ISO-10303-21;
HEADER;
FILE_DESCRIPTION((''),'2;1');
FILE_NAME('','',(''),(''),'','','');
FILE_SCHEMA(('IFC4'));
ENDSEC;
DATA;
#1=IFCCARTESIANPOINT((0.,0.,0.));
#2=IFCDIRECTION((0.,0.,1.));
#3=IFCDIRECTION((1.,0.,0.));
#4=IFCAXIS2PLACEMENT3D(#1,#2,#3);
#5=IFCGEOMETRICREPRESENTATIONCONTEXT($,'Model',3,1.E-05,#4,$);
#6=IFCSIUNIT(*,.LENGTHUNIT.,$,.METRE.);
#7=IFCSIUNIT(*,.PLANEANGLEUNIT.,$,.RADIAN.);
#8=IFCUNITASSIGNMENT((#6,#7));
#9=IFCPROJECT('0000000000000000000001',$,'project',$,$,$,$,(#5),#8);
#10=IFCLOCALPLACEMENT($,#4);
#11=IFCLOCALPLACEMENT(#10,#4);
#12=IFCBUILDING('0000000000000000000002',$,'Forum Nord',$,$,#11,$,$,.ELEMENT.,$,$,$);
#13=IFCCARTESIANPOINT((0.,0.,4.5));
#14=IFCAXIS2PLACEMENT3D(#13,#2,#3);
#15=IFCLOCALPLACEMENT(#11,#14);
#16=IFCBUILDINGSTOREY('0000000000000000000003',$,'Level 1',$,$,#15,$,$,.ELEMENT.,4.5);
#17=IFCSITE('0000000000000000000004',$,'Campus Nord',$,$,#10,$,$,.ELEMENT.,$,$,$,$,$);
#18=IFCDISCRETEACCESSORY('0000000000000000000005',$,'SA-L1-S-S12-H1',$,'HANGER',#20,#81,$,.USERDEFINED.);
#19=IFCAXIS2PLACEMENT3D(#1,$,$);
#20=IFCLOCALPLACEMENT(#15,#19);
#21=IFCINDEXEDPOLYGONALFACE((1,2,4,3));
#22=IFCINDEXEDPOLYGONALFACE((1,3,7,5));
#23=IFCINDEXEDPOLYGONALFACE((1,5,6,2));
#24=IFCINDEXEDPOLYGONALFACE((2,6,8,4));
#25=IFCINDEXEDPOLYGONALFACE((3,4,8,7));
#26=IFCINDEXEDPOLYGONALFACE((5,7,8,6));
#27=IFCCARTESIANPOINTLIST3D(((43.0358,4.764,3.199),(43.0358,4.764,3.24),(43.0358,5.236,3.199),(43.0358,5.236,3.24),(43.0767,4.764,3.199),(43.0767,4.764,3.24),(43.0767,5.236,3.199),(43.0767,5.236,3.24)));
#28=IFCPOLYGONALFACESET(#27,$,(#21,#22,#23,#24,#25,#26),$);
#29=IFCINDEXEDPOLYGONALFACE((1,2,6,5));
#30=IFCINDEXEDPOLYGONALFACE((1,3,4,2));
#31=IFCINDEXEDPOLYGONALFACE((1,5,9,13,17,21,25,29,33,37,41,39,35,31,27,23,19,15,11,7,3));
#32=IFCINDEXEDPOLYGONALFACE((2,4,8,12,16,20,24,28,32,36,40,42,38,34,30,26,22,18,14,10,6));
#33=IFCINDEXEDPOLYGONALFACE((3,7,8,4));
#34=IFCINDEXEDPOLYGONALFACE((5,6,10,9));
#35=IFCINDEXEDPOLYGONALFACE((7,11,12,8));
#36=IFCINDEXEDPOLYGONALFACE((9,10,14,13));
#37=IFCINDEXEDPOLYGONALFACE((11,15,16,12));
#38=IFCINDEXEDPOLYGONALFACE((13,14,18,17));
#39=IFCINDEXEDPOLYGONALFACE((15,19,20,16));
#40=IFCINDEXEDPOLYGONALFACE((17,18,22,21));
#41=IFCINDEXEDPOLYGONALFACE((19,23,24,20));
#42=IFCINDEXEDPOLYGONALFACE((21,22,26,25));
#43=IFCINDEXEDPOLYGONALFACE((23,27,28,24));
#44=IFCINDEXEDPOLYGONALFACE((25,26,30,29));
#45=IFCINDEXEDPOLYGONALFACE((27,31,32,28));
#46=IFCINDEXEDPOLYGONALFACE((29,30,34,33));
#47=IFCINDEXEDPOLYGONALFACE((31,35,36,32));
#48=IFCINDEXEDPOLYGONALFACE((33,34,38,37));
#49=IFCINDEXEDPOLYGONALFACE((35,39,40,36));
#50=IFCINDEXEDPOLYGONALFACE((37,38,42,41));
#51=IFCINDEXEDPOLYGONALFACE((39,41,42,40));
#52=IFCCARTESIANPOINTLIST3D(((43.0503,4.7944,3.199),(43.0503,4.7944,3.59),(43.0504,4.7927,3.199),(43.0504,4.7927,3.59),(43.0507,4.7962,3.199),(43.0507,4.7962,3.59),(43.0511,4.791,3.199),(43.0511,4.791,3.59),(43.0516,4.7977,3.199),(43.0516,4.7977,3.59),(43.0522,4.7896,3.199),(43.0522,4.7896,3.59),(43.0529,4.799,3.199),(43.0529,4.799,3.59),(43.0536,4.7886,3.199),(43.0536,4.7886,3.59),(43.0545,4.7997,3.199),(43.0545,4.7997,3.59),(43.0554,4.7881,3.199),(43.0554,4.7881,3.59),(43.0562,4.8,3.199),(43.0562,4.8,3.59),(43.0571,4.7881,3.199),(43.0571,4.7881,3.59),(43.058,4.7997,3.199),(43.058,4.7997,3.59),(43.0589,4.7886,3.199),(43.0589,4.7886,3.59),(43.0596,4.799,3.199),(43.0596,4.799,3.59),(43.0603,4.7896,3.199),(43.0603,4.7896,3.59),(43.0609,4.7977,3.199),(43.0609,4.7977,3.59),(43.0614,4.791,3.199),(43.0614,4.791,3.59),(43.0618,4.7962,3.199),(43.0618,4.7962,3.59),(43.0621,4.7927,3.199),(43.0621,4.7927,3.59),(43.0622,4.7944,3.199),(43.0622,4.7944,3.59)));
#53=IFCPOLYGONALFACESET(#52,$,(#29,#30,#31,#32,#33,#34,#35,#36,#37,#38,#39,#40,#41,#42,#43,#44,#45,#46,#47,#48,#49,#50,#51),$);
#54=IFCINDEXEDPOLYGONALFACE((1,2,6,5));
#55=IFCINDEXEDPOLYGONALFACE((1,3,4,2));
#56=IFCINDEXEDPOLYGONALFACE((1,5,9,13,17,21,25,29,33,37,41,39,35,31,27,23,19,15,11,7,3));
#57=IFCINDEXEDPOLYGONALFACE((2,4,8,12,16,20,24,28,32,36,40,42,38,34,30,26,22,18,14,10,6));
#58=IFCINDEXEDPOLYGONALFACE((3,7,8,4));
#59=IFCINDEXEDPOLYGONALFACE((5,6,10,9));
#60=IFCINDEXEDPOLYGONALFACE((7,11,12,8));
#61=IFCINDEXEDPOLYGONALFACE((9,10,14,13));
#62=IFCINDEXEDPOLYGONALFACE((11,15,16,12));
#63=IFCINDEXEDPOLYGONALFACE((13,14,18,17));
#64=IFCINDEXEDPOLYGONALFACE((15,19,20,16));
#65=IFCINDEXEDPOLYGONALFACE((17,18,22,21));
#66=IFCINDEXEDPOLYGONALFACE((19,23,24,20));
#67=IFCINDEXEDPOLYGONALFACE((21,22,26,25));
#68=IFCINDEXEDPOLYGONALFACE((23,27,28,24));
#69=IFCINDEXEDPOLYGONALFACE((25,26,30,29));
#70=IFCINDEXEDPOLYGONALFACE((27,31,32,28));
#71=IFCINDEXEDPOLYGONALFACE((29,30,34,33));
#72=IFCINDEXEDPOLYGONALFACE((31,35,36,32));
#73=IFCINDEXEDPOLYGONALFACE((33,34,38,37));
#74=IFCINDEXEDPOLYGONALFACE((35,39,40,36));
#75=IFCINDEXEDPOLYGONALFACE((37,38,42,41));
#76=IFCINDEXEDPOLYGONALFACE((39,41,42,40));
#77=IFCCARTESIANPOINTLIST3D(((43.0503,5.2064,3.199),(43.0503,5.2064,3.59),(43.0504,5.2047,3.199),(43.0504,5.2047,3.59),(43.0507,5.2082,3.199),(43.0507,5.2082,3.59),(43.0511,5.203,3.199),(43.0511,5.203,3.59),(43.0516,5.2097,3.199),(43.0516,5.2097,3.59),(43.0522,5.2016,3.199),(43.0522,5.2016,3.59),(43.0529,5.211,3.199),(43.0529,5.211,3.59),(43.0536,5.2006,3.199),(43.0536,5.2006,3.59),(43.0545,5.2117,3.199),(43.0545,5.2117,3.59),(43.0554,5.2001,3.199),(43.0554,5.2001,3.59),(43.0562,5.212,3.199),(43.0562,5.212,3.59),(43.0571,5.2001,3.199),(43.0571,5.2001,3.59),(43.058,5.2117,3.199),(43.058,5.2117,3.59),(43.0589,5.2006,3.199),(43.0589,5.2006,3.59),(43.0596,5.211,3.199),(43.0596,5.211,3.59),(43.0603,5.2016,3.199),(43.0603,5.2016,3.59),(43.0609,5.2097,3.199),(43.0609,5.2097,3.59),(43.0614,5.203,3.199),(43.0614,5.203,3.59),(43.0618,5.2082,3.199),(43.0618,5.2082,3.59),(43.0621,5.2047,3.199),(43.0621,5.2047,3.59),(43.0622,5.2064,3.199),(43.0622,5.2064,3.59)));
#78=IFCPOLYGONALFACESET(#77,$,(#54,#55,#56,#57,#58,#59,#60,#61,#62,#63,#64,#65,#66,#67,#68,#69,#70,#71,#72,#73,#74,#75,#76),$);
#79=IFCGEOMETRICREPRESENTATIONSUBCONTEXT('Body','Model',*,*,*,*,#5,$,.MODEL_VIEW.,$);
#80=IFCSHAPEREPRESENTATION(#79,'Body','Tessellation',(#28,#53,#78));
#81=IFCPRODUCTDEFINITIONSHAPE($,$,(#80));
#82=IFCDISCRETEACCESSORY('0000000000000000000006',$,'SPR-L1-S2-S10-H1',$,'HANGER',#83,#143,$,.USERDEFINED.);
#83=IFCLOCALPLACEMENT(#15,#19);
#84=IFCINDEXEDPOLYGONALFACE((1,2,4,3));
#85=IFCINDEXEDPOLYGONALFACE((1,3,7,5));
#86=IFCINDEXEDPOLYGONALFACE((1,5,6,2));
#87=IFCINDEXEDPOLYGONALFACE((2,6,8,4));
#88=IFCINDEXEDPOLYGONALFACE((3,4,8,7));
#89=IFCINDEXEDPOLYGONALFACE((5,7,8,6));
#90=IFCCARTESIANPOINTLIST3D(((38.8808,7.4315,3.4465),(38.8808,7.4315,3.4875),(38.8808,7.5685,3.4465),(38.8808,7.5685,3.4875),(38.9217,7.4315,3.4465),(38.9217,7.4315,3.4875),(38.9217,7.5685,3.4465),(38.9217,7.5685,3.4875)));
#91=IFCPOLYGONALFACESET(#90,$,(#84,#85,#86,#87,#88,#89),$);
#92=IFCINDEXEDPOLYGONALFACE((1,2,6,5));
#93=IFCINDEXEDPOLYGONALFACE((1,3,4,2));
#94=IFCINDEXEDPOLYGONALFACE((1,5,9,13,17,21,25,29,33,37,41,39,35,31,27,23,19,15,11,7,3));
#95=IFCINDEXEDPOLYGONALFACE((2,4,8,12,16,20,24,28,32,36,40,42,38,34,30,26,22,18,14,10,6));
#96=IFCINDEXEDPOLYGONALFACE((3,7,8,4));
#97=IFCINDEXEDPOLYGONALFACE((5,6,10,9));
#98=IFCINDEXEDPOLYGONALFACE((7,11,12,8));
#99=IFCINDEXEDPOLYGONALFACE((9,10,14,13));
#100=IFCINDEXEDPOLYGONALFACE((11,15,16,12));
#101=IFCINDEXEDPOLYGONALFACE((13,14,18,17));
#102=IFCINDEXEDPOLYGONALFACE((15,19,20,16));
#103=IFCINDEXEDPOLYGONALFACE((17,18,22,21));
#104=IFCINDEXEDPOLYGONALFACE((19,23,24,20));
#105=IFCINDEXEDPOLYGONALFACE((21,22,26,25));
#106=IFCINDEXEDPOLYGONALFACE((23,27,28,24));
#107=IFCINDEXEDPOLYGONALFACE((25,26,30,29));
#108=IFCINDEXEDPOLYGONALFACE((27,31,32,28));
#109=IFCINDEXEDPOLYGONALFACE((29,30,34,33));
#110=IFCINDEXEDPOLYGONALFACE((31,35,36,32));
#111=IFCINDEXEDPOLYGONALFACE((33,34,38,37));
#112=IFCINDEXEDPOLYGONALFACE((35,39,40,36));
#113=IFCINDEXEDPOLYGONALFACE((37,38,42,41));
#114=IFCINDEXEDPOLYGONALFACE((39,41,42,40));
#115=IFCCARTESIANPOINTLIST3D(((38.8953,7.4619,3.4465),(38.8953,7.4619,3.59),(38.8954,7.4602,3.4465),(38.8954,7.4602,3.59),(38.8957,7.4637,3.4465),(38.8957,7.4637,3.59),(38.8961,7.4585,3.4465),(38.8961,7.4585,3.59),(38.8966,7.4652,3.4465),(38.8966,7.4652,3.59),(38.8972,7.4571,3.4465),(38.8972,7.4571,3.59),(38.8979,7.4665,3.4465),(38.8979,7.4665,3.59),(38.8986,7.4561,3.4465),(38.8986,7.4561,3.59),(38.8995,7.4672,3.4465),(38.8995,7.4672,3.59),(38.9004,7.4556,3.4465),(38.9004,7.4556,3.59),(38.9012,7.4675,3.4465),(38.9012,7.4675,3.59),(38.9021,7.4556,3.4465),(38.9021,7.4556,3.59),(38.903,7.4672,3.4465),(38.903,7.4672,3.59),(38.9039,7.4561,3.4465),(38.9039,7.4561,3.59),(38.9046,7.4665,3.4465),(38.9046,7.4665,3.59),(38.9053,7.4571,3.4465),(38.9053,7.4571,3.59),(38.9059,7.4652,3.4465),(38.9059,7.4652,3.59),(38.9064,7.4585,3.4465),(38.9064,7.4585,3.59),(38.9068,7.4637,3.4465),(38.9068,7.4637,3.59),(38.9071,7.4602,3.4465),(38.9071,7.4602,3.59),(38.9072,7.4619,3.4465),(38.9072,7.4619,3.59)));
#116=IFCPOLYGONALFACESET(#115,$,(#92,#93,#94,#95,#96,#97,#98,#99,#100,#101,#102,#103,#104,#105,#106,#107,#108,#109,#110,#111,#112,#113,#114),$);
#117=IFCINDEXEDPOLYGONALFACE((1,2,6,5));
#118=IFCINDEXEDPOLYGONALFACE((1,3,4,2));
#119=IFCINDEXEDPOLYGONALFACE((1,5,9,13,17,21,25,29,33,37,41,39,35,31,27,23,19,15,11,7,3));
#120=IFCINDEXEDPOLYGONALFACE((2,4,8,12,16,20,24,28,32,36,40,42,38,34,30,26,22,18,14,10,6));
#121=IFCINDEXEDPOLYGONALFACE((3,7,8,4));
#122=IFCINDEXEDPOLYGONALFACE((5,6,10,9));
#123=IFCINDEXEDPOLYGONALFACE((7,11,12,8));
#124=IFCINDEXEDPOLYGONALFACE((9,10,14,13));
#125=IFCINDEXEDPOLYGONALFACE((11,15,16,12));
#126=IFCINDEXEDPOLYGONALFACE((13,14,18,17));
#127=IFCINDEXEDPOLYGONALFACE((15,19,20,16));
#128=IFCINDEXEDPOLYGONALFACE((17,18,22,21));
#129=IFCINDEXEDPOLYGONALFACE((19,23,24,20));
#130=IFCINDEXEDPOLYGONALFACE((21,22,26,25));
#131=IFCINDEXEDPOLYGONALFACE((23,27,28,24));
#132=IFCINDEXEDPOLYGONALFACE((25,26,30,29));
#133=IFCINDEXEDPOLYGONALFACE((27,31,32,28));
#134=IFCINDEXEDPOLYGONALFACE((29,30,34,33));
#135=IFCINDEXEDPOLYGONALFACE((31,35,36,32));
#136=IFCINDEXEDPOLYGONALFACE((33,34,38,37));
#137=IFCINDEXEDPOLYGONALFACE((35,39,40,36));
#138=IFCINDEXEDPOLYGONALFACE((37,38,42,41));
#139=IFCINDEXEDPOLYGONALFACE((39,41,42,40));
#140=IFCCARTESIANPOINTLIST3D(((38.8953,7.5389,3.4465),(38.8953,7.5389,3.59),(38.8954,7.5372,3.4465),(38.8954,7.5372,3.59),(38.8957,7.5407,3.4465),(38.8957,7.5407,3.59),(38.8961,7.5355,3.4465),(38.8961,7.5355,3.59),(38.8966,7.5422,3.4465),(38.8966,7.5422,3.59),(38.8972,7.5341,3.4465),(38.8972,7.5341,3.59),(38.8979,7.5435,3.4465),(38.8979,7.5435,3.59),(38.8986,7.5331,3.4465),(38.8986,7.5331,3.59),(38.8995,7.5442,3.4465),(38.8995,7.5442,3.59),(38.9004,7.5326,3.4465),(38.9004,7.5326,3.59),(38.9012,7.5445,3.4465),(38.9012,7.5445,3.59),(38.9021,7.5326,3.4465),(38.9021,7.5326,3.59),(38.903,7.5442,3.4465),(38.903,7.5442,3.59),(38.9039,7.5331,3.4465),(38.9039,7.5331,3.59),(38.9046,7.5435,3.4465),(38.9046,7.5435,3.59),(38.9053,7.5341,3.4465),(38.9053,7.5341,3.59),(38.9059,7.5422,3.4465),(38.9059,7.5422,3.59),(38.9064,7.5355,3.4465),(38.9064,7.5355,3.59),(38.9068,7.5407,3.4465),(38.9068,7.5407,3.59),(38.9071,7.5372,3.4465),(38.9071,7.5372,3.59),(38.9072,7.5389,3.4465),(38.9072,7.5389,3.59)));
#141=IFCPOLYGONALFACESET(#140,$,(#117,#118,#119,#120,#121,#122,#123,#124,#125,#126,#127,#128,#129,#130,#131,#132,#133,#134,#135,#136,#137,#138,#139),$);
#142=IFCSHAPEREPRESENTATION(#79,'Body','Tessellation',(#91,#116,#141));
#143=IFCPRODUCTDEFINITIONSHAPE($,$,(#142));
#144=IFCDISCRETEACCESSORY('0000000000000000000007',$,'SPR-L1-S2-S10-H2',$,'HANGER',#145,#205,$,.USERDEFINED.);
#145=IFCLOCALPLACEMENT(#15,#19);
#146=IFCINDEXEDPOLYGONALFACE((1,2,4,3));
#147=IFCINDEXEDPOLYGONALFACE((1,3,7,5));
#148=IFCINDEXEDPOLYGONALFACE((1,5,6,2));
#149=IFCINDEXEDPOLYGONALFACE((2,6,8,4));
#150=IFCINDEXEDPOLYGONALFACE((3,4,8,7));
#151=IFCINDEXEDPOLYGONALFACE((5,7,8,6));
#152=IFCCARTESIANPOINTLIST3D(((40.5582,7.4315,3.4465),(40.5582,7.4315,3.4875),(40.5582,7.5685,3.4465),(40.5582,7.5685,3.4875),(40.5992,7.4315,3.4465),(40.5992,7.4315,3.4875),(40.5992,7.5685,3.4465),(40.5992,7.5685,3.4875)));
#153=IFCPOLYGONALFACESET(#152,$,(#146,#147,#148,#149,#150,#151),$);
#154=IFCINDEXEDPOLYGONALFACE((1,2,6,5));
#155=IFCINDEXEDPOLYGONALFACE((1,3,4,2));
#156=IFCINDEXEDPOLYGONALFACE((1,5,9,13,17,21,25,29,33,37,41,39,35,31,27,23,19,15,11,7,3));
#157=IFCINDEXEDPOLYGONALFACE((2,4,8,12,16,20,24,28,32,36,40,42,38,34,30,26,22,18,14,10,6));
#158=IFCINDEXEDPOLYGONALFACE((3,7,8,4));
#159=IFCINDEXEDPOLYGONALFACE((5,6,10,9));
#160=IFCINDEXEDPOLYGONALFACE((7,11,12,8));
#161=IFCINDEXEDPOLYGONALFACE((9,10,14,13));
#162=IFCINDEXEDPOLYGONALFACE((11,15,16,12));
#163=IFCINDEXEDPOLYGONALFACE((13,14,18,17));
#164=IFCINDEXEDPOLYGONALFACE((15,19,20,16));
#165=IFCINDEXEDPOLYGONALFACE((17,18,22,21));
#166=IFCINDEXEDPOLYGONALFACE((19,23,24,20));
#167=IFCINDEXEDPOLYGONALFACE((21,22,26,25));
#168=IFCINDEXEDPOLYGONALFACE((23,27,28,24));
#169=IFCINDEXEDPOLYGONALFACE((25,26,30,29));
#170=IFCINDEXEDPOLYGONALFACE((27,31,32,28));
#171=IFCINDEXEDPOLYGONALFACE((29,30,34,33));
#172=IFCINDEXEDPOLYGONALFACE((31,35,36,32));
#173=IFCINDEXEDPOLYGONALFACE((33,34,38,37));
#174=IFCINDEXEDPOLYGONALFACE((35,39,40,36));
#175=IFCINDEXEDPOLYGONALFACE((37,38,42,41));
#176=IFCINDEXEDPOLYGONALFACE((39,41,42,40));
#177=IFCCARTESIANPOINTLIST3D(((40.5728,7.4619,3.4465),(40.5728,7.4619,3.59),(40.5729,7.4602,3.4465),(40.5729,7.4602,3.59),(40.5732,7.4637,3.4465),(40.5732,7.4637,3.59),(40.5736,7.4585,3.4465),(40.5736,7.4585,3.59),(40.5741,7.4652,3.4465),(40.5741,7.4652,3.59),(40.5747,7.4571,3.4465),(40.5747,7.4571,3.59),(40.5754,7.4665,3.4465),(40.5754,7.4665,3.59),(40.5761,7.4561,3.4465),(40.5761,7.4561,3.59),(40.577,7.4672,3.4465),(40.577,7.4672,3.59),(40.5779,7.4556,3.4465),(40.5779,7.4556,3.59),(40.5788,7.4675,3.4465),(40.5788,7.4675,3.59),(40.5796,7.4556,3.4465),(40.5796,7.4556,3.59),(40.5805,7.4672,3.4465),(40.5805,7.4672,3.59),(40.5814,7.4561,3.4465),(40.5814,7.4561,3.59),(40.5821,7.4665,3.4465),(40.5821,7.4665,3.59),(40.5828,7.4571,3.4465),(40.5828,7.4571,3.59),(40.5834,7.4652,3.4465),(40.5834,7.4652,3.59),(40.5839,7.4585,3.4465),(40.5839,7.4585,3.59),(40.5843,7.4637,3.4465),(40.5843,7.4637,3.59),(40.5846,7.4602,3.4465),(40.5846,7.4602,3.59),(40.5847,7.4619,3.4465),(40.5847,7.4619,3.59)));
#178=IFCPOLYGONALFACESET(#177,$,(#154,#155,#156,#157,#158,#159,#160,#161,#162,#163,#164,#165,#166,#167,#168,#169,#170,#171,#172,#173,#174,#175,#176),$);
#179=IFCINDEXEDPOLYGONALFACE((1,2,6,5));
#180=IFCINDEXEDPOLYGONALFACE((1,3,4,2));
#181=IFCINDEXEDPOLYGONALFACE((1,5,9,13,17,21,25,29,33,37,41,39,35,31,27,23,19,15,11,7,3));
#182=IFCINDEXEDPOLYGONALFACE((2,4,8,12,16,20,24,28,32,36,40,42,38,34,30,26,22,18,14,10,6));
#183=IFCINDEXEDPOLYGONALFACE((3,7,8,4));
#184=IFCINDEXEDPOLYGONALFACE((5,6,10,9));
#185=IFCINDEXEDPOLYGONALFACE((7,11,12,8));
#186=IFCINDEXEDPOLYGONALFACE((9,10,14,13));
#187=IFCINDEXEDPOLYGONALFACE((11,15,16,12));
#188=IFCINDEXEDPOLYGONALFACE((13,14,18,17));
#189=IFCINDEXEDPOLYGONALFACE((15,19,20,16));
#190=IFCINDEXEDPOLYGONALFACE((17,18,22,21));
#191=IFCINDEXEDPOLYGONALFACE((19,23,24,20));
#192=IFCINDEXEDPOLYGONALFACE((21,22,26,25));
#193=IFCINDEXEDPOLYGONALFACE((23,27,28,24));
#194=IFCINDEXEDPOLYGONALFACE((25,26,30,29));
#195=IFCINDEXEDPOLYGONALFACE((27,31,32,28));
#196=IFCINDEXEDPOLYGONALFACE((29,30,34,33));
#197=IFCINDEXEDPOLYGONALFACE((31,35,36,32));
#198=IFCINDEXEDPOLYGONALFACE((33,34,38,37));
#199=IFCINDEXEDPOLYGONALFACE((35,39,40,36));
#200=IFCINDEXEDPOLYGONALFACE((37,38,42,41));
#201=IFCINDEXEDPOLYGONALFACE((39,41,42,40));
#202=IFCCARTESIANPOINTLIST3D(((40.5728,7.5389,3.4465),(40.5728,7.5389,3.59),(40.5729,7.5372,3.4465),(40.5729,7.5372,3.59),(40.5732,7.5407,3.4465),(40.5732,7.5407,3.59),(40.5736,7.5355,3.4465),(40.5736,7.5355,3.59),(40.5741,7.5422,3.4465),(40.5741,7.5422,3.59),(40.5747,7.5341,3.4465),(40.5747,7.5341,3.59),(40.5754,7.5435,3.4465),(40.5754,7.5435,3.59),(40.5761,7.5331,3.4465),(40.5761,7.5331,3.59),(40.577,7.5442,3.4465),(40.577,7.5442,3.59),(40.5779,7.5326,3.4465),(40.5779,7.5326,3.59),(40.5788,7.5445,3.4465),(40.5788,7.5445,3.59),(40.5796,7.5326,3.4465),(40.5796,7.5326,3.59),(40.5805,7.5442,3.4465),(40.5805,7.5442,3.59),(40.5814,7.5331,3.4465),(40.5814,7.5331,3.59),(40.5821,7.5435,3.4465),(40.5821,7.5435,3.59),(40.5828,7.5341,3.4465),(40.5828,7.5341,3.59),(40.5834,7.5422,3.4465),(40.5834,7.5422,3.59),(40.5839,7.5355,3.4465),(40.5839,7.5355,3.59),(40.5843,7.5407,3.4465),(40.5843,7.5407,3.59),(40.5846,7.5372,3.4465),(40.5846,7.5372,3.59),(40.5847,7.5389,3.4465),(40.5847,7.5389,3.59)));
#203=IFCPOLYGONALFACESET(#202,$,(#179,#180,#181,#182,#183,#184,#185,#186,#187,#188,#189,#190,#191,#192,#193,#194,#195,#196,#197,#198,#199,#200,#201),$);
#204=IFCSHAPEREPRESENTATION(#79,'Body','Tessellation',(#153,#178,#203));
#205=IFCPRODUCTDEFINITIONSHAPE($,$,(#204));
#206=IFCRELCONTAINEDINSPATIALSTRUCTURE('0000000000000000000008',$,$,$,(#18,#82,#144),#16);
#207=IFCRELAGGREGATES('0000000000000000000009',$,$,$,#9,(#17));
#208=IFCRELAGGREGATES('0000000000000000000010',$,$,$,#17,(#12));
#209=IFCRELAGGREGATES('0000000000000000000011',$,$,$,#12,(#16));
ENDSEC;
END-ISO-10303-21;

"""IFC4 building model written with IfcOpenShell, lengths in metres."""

from ifc_helpers import new_model, si_unit, frame, frame_2d, origin_with_axes, origin_2d_with_axis, place, context, subcontext, project, spatial, rectangle, circle, extrude, element, save


model = new_model("IFC4")

# Units and contexts
model_context = context("Model", 3, precision=1e-05, world=origin_with_axes())
body_context = subcontext(model_context, "Body", "Model", "MODEL_VIEW")
ifc_project = project(units=[si_unit("LENGTHUNIT", "METRE"), si_unit("PLANEANGLEUNIT", "RADIAN")], contexts=[model_context])

# Site, building, storey
site_placement = place(None, origin_with_axes())
site = spatial("IfcSite", under=ifc_project, at=site_placement, Name="Campus Nord", CompositionType="ELEMENT")
building_placement = place(site_placement, origin_with_axes())
building = spatial("IfcBuilding", under=site, at=building_placement, Name="Forum Nord", CompositionType="ELEMENT")
storey_placement = place(building_placement, frame((0.0, 0.0, 4.5), z_axis=(0.0, 0.0, 1.0), x_axis=(1.0, 0.0, 0.0)))
storey = spatial("IfcBuildingStorey", under=building, at=storey_placement, Name="Level 1", CompositionType="ELEMENT", Elevation=4.5)

# Discrete accessories
for number, where, z_axis, x_axis, name in (
    (1, (43.0562, 5.0, 3.24), (0.0, 0.0, 1.0), (0.0, 1.0, 0.0), "SA-L1-S-S12-H1"),
):
    element("IfcDiscreteAccessory", number, at=place(storey_placement, frame(where, z_axis=z_axis, x_axis=x_axis)), inside=storey, Name=name, ObjectType="HANGER", PredefinedType="USERDEFINED", context=body_context, shape_type="SweptSolid", body=[
        extrude(rectangle(XDim=0.472, YDim=0.041, at=origin_2d_with_axis()), frame((0.0, 0.0, -0.041), z_axis=(0.0, 0.0, 1.0), x_axis=(1.0, 0.0, 0.0)), (0.0, 0.0, 1.0), 0.041),
        extrude(circle(Radius=0.006, at=frame_2d((-0.206, 0.0), x_axis=(1.0, 0.0))), frame((0.0, 0.0, -0.041), z_axis=(0.0, 0.0, 1.0), x_axis=(1.0, 0.0, 0.0)), (0.0, 0.0, 1.0), 0.391),
        extrude(circle(Radius=0.006, at=frame_2d((0.206, 0.0), x_axis=(1.0, 0.0))), frame((0.0, 0.0, -0.041), z_axis=(0.0, 0.0, 1.0), x_axis=(1.0, 0.0, 0.0)), (0.0, 0.0, 1.0), 0.391),
    ])
for number, where, z_axis, x_axis, name in (
    (2, (38.9012, 7.5, 3.4875), (0.0, 0.0, 1.0), (0.0, 1.0, 0.0), "SPR-L1-S2-S10-H1"),
    (3, (40.5787, 7.5, 3.4875), (0.0, 0.0, 1.0), (0.0, 1.0, 0.0), "SPR-L1-S2-S10-H2"),
):
    element("IfcDiscreteAccessory", number, at=place(storey_placement, frame(where, z_axis=z_axis, x_axis=x_axis)), inside=storey, Name=name, ObjectType="HANGER", PredefinedType="USERDEFINED", context=body_context, shape_type="SweptSolid", body=[
        extrude(rectangle(XDim=0.137, YDim=0.041, at=origin_2d_with_axis()), frame((0.0, 0.0, -0.041), z_axis=(0.0, 0.0, 1.0), x_axis=(1.0, 0.0, 0.0)), (0.0, 0.0, 1.0), 0.041),
        extrude(circle(Radius=0.006, at=frame_2d((-0.0385, 0.0), x_axis=(1.0, 0.0))), frame((0.0, 0.0, -0.041), z_axis=(0.0, 0.0, 1.0), x_axis=(1.0, 0.0, 0.0)), (0.0, 0.0, 1.0), 0.1435),
        extrude(circle(Radius=0.006, at=frame_2d((0.0385, 0.0), x_axis=(1.0, 0.0))), frame((0.0, 0.0, -0.041), z_axis=(0.0, 0.0, 1.0), x_axis=(1.0, 0.0, 0.0)), (0.0, 0.0, 1.0), 0.1435),
    ])

save(model, "model.ifc")
